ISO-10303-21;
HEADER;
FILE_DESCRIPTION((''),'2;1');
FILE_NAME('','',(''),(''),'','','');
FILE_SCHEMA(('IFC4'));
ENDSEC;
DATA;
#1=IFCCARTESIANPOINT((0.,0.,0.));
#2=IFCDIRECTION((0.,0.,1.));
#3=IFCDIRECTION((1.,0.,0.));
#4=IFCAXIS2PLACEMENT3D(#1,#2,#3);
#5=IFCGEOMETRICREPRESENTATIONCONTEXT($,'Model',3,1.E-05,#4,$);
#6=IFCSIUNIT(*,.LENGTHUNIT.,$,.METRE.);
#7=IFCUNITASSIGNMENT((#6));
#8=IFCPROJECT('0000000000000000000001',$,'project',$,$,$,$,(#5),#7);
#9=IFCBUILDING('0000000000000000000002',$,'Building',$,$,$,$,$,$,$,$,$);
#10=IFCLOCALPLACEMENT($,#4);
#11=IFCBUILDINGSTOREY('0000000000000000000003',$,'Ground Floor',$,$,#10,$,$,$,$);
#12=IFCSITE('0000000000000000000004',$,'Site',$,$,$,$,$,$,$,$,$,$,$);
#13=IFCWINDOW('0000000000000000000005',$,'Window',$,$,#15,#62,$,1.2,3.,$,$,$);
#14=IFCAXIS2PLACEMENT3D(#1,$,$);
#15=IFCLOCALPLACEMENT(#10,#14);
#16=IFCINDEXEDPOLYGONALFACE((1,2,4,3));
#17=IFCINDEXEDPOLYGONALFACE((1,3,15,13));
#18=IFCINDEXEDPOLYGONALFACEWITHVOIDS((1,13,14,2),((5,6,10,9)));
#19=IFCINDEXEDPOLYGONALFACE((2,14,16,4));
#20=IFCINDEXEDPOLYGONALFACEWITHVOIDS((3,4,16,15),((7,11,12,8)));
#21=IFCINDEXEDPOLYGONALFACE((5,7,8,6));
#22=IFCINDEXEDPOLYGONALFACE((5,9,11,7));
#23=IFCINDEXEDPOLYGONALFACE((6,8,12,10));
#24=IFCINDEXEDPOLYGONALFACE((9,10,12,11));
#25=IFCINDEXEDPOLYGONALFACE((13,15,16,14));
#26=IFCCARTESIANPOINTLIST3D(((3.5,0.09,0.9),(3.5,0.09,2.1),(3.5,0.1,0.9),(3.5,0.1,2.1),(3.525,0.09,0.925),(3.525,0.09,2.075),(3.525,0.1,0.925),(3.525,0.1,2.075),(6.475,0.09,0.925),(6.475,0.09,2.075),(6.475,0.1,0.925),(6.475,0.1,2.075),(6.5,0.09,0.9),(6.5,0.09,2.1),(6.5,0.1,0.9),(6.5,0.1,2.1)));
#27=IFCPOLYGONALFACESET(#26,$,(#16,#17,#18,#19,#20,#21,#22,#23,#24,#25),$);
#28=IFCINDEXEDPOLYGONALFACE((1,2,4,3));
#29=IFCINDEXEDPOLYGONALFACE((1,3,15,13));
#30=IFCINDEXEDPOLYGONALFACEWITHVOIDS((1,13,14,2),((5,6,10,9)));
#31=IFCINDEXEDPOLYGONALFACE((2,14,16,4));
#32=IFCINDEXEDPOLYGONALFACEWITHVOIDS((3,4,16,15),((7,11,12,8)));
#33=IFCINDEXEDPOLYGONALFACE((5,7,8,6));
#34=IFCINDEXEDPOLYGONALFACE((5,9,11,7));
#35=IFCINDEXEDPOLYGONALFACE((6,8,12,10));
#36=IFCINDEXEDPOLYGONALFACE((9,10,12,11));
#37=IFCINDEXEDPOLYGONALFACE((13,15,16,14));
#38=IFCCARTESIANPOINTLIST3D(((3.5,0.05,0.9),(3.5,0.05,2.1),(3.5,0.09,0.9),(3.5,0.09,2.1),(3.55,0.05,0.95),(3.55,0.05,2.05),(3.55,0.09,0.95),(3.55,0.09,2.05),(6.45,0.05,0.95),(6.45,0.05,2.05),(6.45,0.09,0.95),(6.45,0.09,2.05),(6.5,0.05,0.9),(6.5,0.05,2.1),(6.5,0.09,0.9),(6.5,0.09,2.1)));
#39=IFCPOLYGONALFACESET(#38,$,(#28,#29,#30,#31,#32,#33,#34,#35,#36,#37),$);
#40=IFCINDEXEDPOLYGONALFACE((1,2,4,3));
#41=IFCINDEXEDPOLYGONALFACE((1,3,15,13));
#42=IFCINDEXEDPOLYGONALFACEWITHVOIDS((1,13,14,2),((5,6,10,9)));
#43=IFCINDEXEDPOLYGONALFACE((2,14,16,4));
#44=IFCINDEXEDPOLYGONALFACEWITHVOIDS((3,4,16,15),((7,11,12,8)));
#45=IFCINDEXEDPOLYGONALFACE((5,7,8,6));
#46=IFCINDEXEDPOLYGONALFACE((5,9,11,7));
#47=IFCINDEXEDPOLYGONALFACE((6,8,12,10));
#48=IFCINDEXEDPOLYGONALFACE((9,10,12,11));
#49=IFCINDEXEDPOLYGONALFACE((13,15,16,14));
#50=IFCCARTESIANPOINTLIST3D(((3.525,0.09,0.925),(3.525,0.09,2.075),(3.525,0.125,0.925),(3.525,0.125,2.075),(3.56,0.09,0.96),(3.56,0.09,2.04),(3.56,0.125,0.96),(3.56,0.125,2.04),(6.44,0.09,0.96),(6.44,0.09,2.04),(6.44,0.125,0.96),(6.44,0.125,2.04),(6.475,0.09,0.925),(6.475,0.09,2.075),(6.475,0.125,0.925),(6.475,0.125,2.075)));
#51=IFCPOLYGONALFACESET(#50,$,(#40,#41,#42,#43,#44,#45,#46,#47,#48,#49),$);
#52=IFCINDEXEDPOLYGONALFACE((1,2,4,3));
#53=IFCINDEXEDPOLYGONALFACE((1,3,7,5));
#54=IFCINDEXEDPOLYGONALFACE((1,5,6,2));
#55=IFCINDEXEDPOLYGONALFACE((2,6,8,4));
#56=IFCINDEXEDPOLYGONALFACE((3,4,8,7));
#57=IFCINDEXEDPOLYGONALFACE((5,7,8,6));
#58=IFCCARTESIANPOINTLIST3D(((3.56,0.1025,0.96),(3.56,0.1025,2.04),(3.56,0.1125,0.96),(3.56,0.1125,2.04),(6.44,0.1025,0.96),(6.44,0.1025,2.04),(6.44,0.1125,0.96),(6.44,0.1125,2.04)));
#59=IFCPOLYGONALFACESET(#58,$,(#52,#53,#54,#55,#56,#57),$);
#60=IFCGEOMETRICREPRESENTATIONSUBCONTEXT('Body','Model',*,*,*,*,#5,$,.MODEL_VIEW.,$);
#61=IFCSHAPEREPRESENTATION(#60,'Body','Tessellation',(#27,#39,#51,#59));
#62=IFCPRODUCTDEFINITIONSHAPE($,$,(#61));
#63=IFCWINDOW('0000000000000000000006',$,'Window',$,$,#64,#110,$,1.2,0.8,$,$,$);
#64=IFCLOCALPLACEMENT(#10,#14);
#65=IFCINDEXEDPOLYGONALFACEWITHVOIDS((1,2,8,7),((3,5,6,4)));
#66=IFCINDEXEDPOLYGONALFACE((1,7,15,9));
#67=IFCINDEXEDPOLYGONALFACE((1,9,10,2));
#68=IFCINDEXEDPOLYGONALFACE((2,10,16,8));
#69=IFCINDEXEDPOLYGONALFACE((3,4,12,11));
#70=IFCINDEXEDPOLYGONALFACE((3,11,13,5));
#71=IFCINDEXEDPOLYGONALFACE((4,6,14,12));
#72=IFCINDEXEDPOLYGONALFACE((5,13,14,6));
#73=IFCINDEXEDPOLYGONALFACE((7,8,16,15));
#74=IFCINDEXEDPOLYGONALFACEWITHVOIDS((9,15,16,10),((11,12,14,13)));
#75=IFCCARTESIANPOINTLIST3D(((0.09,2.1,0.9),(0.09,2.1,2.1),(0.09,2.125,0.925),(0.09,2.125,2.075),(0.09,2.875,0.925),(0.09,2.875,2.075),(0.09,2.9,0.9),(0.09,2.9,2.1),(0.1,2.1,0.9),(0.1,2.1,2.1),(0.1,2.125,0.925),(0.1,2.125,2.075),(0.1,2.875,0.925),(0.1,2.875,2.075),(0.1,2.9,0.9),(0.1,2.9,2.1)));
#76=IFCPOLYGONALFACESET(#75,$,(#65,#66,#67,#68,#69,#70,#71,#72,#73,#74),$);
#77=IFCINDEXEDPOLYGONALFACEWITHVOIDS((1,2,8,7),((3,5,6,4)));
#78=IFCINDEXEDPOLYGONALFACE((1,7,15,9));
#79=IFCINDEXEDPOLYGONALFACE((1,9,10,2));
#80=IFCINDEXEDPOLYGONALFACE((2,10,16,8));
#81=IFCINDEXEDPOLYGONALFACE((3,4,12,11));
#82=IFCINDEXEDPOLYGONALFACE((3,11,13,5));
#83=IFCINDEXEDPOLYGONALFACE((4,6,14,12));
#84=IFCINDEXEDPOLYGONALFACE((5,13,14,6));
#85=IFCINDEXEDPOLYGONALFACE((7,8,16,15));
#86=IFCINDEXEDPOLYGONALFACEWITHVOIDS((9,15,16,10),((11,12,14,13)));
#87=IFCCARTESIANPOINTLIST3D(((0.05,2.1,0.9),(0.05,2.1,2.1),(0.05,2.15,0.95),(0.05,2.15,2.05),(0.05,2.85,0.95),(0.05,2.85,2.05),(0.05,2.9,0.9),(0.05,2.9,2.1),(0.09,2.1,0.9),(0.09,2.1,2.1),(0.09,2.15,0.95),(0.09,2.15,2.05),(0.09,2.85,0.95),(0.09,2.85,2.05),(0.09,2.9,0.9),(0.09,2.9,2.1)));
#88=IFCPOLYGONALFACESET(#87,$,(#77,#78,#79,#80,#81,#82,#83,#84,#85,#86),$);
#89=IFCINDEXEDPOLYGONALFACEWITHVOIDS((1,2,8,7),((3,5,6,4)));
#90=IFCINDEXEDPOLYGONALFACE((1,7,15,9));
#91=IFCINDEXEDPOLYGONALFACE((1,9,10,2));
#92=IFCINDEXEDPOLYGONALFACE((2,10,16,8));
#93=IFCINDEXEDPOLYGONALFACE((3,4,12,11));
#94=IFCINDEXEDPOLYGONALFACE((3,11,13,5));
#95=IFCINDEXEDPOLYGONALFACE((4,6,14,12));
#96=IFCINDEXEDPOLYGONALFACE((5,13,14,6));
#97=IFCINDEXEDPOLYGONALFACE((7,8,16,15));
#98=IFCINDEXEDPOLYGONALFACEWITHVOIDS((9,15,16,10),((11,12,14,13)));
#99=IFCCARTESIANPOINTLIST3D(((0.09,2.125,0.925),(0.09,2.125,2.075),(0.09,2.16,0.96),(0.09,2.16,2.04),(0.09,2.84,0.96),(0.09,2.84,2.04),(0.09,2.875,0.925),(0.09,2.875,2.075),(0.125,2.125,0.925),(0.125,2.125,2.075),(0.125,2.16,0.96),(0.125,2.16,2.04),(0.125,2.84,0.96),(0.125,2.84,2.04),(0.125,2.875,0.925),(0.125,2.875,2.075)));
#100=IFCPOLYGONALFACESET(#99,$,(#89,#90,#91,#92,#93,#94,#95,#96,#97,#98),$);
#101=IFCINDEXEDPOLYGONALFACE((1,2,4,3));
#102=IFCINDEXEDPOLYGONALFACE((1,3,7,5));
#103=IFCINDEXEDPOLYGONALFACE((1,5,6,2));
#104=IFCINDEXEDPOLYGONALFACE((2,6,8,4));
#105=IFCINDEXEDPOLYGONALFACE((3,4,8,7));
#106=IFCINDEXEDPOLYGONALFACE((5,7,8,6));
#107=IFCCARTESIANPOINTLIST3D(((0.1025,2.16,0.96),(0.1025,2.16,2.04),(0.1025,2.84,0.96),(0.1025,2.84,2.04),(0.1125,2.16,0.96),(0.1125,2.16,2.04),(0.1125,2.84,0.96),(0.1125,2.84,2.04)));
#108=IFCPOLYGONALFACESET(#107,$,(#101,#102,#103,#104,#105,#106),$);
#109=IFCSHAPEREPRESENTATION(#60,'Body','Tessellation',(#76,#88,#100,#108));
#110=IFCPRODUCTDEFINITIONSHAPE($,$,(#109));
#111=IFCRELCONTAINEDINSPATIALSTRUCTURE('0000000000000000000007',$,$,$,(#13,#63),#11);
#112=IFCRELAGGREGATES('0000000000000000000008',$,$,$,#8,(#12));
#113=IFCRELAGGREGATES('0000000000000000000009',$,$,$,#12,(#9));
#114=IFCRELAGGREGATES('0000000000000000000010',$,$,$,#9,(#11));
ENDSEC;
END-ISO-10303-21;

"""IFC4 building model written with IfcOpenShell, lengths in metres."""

from ifc_helpers import new_model, si_unit, frame, origin_with_axes, place, context, subcontext, project, spatial, line, indexed_curve, outline, extrude, element, save


model = new_model("IFC4")

# Units and contexts
model_context = context("Model", 3, precision=1e-05, world=origin_with_axes())
body_context = subcontext(model_context, "Body", "Model", "MODEL_VIEW")
ifc_project = project(units=[si_unit("LENGTHUNIT", "METRE")], contexts=[model_context])

# Site, building, storey
site = spatial("IfcSite", under=ifc_project, Name="Site")
building = spatial("IfcBuilding", under=site, Name="Building")
storey_placement = place(None, origin_with_axes())
storey = spatial("IfcBuildingStorey", under=building, at=storey_placement, Name="Ground Floor")

# Windows
window_1_placement = place(storey_placement, frame((3.5, 0.0, 0.9), z_axis=(0.0, 0.0, 1.0), x_axis=(1.0, 0.0, 0.0)))
element("IfcWindow", 1, at=window_1_placement, inside=storey, Name="Window", OverallHeight=1.2, OverallWidth=3.0, context=body_context, shape_type="SweptSolid", body=[
    extrude(outline(indexed_curve([(0.0, 0.0), (3.0, 0.0), (3.0, 1.2), (0.0, 1.2)], segments=[line(1, 2, 3, 4, 1)]), holes=[indexed_curve([(0.025, 0.025), (2.975, 0.025), (2.975, 1.175), (0.025, 1.175)], segments=[line(1, 2, 3, 4, 1)])]), frame((0.0, 0.09, 0.0), z_axis=(0.0, -1.0, 0.0), x_axis=(1.0, 0.0, 0.0)), (0.0, 0.0, -1.0), 0.01),
    extrude(outline(indexed_curve([(0.0, 0.0), (3.0, 0.0), (3.0, 1.2), (0.0, 1.2)], segments=[line(1, 2, 3, 4, 1)]), holes=[indexed_curve([(0.05, 0.05), (2.95, 0.05), (2.95, 1.15), (0.05, 1.15)], segments=[line(1, 2, 3, 4, 1)])]), frame((0.0, 0.05, 0.0), z_axis=(0.0, -1.0, 0.0), x_axis=(1.0, 0.0, 0.0)), (0.0, 0.0, -1.0), 0.04),
    extrude(outline(indexed_curve([(0.0, 0.0), (2.95, 0.0), (2.95, 1.15), (0.0, 1.15)], segments=[line(1, 2, 3, 4, 1)]), holes=[indexed_curve([(0.035, 0.035), (2.915, 0.035), (2.915, 1.115), (0.035, 1.115)], segments=[line(1, 2, 3, 4, 1)])]), frame((0.025, 0.09, 0.025), z_axis=(0.0, -1.0, 0.0), x_axis=(1.0, 0.0, 0.0)), (0.0, 0.0, -1.0), 0.035),
    extrude(outline(indexed_curve([(0.035, 0.035), (2.915, 0.035), (2.915, 1.115), (0.035, 1.115)], segments=[line(1, 2, 3, 4, 1)])), frame((0.025, 0.1025, 0.025), z_axis=(0.0, -1.0, 0.0), x_axis=(1.0, 0.0, 0.0)), (0.0, 0.0, -1.0), 0.01),
])
window_2_placement = place(storey_placement, frame((0.0, 2.9, 0.9), z_axis=(0.0, 0.0, 1.0), x_axis=(0.0, -1.0, 0.0)))
element("IfcWindow", 2, at=window_2_placement, inside=storey, Name="Window", OverallHeight=1.2, OverallWidth=0.8, context=body_context, shape_type="SweptSolid", body=[
    extrude(outline(indexed_curve([(0.0, 0.0), (0.8, 0.0), (0.8, 1.2), (0.0, 1.2)], segments=[line(1, 2, 3, 4, 1)]), holes=[indexed_curve([(0.025, 0.025), (0.775, 0.025), (0.775, 1.175), (0.025, 1.175)], segments=[line(1, 2, 3, 4, 1)])]), frame((0.0, 0.09, 0.0), z_axis=(0.0, -1.0, 0.0), x_axis=(1.0, 0.0, 0.0)), (0.0, 0.0, -1.0), 0.01),
    extrude(outline(indexed_curve([(0.0, 0.0), (0.8, 0.0), (0.8, 1.2), (0.0, 1.2)], segments=[line(1, 2, 3, 4, 1)]), holes=[indexed_curve([(0.05, 0.05), (0.75, 0.05), (0.75, 1.15), (0.05, 1.15)], segments=[line(1, 2, 3, 4, 1)])]), frame((0.0, 0.05, 0.0), z_axis=(0.0, -1.0, 0.0), x_axis=(1.0, 0.0, 0.0)), (0.0, 0.0, -1.0), 0.04),
    extrude(outline(indexed_curve([(0.0, 0.0), (0.75, 0.0), (0.75, 1.15), (0.0, 1.15)], segments=[line(1, 2, 3, 4, 1)]), holes=[indexed_curve([(0.035, 0.035), (0.715, 0.035), (0.715, 1.115), (0.035, 1.115)], segments=[line(1, 2, 3, 4, 1)])]), frame((0.025, 0.09, 0.025), z_axis=(0.0, -1.0, 0.0), x_axis=(1.0, 0.0, 0.0)), (0.0, 0.0, -1.0), 0.035),
    extrude(outline(indexed_curve([(0.035, 0.035), (0.715, 0.035), (0.715, 1.115), (0.035, 1.115)], segments=[line(1, 2, 3, 4, 1)])), frame((0.025, 0.1025, 0.025), z_axis=(0.0, -1.0, 0.0), x_axis=(1.0, 0.0, 0.0)), (0.0, 0.0, -1.0), 0.01),
])

save(model, "model.ifc")
